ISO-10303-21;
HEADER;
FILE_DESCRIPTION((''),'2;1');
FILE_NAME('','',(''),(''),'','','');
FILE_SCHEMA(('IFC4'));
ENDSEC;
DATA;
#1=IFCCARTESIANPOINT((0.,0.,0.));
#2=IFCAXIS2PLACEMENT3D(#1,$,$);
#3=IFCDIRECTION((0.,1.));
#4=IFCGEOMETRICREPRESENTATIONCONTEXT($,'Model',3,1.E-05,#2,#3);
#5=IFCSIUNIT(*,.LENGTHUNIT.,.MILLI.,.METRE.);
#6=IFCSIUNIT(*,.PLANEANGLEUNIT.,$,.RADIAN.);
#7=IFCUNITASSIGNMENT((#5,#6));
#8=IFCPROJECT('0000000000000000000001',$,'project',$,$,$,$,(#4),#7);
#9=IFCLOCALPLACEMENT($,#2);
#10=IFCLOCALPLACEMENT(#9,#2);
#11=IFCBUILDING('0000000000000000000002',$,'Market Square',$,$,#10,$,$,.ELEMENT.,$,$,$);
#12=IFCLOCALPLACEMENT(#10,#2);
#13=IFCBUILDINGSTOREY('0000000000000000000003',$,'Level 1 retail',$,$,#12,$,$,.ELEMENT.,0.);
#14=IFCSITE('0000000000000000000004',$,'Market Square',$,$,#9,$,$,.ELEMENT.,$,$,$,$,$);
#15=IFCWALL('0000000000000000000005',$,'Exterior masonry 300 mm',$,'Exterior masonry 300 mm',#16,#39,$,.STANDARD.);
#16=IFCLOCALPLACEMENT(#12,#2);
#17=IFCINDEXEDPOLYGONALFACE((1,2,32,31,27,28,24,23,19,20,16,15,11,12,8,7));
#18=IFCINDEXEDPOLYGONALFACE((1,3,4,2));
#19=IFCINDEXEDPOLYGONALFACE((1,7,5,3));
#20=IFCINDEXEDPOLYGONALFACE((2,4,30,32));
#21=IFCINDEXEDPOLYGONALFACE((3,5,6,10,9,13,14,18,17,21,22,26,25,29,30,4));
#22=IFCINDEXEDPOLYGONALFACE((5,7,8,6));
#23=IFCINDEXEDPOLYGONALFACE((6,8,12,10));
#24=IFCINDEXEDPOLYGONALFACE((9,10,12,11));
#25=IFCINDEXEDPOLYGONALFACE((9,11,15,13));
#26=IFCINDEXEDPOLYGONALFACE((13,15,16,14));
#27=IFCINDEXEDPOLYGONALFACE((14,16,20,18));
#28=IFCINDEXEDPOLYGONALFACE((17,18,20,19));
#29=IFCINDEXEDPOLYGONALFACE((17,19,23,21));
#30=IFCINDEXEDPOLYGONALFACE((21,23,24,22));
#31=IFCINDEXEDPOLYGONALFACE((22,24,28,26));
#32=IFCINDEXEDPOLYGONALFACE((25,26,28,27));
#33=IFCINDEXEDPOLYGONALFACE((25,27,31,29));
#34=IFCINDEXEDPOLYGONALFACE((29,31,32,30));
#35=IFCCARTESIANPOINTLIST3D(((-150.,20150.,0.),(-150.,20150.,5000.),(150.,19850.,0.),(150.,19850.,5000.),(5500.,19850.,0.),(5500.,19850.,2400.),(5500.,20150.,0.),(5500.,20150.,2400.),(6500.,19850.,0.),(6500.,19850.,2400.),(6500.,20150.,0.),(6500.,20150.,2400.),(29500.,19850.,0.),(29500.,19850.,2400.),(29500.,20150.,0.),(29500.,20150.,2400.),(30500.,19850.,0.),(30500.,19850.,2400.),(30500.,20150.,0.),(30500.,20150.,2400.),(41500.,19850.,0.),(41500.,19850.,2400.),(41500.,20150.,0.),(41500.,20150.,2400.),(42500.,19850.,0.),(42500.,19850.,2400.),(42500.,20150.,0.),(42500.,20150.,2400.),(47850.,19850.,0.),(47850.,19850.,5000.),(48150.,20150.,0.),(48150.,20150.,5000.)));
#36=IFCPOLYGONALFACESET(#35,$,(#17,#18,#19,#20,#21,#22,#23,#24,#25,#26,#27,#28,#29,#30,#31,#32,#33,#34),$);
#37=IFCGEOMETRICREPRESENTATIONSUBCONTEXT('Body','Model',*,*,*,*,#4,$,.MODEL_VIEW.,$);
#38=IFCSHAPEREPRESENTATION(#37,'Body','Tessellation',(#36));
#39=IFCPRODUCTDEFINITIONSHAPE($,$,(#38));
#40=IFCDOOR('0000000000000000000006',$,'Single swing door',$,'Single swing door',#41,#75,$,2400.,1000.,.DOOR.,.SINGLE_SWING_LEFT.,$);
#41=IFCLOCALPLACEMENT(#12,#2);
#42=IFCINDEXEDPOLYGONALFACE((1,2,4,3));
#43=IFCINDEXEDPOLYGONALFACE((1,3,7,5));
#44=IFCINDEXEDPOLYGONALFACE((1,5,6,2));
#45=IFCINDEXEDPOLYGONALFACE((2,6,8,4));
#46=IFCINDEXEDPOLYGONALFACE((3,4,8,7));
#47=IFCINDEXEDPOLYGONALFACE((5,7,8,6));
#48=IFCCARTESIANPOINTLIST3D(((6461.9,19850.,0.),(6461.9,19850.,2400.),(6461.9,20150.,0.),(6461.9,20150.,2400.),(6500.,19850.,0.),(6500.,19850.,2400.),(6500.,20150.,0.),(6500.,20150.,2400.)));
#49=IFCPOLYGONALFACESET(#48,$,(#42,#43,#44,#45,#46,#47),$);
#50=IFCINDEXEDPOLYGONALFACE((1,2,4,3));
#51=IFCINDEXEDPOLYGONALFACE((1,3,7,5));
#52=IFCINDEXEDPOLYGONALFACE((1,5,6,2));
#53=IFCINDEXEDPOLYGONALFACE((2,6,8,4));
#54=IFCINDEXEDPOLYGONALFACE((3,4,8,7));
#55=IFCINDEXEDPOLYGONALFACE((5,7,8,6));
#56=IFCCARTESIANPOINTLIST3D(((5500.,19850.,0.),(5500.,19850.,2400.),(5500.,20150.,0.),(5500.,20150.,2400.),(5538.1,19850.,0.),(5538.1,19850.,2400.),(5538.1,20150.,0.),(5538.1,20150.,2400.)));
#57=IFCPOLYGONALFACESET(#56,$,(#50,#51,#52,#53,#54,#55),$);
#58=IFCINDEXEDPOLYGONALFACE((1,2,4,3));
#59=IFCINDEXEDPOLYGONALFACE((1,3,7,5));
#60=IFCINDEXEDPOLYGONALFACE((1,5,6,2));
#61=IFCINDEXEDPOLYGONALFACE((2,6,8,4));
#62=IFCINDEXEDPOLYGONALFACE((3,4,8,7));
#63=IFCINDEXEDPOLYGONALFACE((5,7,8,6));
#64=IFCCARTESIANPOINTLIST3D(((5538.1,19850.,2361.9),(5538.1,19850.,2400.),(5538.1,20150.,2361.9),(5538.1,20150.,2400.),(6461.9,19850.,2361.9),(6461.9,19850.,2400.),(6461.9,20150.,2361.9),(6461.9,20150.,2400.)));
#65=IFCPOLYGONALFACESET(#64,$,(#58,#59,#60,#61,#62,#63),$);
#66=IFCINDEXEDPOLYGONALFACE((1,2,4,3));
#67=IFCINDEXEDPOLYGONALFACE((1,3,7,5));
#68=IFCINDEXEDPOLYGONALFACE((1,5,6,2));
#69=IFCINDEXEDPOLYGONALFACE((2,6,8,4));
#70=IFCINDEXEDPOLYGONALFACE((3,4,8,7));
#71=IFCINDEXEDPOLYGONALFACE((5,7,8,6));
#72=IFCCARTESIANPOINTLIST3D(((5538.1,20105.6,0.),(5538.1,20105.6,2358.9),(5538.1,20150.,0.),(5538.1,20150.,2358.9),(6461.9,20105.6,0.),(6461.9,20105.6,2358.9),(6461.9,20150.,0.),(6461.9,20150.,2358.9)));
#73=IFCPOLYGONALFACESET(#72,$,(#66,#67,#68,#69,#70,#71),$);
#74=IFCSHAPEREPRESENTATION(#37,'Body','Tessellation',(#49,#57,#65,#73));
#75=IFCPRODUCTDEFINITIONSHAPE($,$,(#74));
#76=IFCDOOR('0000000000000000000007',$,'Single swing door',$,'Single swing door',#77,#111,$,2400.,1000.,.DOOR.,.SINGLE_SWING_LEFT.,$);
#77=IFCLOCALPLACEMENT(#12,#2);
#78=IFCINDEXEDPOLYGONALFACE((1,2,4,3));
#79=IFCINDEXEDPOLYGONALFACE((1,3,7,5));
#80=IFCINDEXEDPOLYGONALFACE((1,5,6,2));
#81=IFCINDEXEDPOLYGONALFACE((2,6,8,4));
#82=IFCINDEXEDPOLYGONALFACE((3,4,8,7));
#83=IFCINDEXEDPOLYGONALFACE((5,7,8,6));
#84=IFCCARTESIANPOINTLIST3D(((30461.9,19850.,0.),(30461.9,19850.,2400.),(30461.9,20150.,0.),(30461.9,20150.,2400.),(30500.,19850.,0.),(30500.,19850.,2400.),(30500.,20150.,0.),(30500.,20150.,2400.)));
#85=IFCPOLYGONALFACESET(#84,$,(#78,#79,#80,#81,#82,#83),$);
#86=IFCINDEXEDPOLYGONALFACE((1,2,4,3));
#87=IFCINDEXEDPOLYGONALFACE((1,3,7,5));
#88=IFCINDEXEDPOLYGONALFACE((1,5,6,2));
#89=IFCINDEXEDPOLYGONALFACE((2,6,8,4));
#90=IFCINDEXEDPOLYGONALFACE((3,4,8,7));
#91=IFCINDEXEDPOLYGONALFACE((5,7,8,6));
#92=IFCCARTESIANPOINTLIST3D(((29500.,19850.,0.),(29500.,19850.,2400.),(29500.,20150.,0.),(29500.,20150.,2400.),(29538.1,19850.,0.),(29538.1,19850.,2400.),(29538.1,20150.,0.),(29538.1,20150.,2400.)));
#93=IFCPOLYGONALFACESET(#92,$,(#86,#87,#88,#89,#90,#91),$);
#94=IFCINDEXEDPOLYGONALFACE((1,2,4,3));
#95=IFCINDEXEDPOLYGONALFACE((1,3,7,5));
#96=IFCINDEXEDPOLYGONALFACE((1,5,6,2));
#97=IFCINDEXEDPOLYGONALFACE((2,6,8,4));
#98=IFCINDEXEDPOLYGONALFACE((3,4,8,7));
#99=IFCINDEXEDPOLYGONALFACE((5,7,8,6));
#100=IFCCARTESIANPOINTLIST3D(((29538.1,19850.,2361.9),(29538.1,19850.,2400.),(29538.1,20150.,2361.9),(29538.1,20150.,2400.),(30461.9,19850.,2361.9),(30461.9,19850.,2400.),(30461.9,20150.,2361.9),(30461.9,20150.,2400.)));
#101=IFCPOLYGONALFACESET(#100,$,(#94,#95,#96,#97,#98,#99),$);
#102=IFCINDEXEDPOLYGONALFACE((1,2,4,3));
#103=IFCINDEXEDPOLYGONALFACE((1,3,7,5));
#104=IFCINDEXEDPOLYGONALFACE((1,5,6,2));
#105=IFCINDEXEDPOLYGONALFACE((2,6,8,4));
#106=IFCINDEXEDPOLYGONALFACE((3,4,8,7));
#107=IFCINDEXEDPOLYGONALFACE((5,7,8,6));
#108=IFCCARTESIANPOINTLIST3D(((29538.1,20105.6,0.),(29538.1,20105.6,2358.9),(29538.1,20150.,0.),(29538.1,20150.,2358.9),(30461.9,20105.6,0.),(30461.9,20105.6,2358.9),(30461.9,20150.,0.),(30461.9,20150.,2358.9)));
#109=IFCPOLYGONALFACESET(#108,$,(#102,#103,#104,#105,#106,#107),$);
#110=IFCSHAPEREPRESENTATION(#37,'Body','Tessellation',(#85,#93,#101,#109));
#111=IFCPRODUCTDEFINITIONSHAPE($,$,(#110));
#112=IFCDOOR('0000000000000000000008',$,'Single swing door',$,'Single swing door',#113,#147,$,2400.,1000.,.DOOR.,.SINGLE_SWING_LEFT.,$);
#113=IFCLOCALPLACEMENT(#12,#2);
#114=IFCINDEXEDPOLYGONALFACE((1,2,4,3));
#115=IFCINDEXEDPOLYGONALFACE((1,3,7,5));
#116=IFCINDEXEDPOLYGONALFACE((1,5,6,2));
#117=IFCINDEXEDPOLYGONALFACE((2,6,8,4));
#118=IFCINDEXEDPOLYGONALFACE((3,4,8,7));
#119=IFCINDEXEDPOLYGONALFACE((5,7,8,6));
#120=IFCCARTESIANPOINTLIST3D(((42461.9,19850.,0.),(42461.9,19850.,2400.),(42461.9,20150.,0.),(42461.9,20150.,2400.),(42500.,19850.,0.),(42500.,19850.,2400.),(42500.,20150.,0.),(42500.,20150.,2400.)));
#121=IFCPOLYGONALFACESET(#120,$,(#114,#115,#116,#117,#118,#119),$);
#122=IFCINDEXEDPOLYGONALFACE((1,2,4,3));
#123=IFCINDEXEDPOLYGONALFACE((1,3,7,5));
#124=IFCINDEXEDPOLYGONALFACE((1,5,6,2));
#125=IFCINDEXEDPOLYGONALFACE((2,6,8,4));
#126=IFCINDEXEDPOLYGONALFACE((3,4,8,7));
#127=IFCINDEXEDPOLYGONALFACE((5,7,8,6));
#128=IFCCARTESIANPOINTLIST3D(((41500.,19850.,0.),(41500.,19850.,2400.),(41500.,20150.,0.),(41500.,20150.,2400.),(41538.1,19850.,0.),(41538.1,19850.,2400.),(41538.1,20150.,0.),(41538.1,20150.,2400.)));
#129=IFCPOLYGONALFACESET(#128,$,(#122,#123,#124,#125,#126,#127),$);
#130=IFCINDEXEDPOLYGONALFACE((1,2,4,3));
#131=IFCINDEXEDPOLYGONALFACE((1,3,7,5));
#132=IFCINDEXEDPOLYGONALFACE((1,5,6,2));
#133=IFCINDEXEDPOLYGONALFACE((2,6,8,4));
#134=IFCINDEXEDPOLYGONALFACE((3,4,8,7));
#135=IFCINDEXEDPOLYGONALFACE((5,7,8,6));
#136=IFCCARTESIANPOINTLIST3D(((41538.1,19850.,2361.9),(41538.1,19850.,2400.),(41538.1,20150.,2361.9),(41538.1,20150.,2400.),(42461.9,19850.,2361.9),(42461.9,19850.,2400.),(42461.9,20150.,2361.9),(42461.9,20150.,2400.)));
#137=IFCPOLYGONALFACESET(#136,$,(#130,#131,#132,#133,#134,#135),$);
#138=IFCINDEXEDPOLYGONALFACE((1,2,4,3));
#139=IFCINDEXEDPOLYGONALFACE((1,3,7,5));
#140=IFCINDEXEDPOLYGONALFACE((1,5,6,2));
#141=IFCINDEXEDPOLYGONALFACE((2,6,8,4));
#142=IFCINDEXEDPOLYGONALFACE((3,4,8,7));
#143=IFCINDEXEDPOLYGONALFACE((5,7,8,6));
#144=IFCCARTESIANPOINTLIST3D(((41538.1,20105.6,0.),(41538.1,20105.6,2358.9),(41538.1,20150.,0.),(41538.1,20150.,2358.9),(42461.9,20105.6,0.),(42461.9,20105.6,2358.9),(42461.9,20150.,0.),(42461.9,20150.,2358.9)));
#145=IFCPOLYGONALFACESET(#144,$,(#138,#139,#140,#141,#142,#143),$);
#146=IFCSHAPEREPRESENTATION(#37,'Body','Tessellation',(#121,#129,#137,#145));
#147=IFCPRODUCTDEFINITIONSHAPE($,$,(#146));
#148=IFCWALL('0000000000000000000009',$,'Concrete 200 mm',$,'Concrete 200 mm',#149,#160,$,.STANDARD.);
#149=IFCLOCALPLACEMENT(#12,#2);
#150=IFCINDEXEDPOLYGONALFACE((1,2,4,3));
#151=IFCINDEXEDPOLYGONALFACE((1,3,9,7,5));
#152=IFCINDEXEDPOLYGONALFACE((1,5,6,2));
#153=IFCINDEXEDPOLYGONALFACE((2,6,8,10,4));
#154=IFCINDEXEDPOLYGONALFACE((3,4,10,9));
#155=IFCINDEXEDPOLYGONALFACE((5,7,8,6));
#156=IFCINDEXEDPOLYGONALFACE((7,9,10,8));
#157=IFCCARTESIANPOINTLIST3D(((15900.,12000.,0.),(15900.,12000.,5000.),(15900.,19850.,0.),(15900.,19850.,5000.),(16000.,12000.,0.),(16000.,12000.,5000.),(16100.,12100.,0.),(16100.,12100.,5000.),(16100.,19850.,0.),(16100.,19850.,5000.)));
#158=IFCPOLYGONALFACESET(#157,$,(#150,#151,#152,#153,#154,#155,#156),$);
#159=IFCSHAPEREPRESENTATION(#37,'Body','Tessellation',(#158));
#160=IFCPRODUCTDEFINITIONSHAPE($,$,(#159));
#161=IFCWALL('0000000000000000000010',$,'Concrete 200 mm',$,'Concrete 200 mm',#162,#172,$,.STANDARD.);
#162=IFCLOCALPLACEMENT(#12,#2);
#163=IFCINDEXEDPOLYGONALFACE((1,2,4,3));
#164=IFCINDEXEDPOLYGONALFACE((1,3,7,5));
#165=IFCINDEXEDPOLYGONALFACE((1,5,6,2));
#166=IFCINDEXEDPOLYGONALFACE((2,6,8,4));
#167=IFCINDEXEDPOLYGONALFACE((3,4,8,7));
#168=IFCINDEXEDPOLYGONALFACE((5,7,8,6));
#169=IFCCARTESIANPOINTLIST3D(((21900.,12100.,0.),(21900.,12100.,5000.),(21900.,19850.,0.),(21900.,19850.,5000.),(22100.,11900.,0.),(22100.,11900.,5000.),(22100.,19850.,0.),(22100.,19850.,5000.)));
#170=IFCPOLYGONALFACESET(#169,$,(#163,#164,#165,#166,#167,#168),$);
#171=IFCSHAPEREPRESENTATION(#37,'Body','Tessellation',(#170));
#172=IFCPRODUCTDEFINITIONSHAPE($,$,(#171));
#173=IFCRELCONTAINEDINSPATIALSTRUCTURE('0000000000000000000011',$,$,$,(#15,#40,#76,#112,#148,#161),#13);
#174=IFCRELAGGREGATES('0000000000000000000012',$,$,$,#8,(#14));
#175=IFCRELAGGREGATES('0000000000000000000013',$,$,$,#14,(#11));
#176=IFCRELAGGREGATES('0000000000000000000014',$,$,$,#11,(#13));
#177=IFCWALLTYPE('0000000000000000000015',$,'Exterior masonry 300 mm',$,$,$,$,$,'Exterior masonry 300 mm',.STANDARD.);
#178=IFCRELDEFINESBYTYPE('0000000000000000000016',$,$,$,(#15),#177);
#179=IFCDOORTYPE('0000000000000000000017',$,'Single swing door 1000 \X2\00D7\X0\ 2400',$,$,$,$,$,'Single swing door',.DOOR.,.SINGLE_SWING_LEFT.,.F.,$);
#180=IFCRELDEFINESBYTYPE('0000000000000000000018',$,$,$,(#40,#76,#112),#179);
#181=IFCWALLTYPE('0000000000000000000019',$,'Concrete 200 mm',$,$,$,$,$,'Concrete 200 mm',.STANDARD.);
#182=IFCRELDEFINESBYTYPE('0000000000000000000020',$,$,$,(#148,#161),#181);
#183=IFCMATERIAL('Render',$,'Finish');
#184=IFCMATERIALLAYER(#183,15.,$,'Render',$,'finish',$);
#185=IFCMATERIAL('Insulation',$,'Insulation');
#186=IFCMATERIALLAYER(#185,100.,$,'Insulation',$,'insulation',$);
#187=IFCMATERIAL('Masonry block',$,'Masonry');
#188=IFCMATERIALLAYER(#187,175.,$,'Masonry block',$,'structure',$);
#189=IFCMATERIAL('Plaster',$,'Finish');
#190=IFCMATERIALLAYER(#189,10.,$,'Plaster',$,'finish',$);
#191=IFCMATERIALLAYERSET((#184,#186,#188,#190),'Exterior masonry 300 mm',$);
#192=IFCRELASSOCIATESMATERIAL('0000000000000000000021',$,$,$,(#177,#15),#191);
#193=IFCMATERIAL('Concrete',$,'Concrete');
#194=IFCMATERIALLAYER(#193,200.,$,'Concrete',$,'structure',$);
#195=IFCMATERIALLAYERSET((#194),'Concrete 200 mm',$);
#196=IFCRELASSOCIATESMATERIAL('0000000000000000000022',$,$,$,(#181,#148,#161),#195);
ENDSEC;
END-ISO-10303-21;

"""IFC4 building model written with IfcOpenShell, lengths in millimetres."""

from ifc_helpers import new_model, si_unit, direction, frame, origin, origin_with_axes, place, context, subcontext, project, spatial, polyline, outline, extrude, material, layer, layer_set, layer_usage, type_object, element, fill, save


model = new_model("IFC4")

# Units and contexts
model_context = context("Model", 3, precision=1e-05, world=origin(), true_north=direction((0.0, 1.0)))
body_context = subcontext(model_context, "Body", "Model", "MODEL_VIEW")
ifc_project = project(units=[si_unit("LENGTHUNIT", "METRE", prefix="MILLI"), si_unit("PLANEANGLEUNIT", "RADIAN")], contexts=[model_context])

# Site, building, storey
site_placement = place(None, origin())
site = spatial("IfcSite", under=ifc_project, at=site_placement, Name="Market Square", CompositionType="ELEMENT")
building_placement = place(site_placement, origin())
building = spatial("IfcBuilding", under=site, at=building_placement, Name="Market Square", CompositionType="ELEMENT")
storey_placement = place(building_placement, origin())
storey = spatial("IfcBuildingStorey", under=building, at=storey_placement, Name="Level 1 retail", CompositionType="ELEMENT", Elevation=0.0)

# Shared definitions
ifc_material_1 = material(Name="Render", Category="Finish")
ifc_layer_1 = layer(ifc_material_1, 15.0, Name="Render", Category="finish")
ifc_material_2 = material(Name="Insulation", Category="Insulation")
ifc_layer_2 = layer(ifc_material_2, 100.0, Name="Insulation", Category="insulation")
ifc_material_3 = material(Name="Masonry block", Category="Masonry")
ifc_layer_3 = layer(ifc_material_3, 175.0, Name="Masonry block", Category="structure")
ifc_material_4 = material(Name="Plaster", Category="Finish")
ifc_layer_4 = layer(ifc_material_4, 10.0, Name="Plaster", Category="finish")
ifc_layer_set_1 = layer_set([ifc_layer_1, ifc_layer_2, ifc_layer_3, ifc_layer_4], Name="Exterior masonry 300 mm")
wall_type_1 = type_object("IfcWallType", Name="Exterior masonry 300 mm", ElementType="Exterior masonry 300 mm", PredefinedType="STANDARD", material=ifc_layer_set_1)

# Wall, openings, doors
ifc_layer_usage_1 = layer_usage(ifc_layer_set_1, "AXIS2", "POSITIVE", -150.0)
wall_1_placement = place(storey_placement, frame((48000.0, 20000.0, 0.0), z_axis=(0.0, 0.0, 1.0), x_axis=(-1.0, 0.0, 0.0)))
wall_1 = element("IfcWall", 1, at=wall_1_placement, inside=storey, type_object=wall_type_1, material=ifc_layer_usage_1, Name="Exterior masonry 300 mm", ObjectType="Exterior masonry 300 mm", PredefinedType="STANDARD", context=body_context, shape_type="SweptSolid", body=[
    extrude(outline(polyline([(-150.0, -150.0), (48150.0, -150.0), (47850.0, 150.0), (150.0, 150.0), (-150.0, -150.0)])), origin(), (0.0, 0.0, 1.0), 5000.0),
])
opening_1_placement = place(wall_1_placement, frame((41500.0, 0.0, 0.0), z_axis=(0.0, 0.0, 1.0), x_axis=(1.0, 0.0, 0.0)))
opening_1 = element("IfcOpeningElement", 2, at=opening_1_placement, cuts=wall_1, PredefinedType="OPENING", context=body_context, shape_type="SweptSolid", body=[
    extrude(outline(polyline([(0.0, -160.0), (1000.0, -160.0), (1000.0, 160.0), (0.0, 160.0), (0.0, -160.0)])), origin(), (0.0, 0.0, 1.0), 2400.0),
])
opening_2_placement = place(wall_1_placement, frame((17500.0, 0.0, 0.0), z_axis=(0.0, 0.0, 1.0), x_axis=(1.0, 0.0, 0.0)))
opening_2 = element("IfcOpeningElement", 3, at=opening_2_placement, cuts=wall_1, PredefinedType="OPENING", context=body_context, shape_type="SweptSolid", body=[
    extrude(outline(polyline([(0.0, -160.0), (1000.0, -160.0), (1000.0, 160.0), (0.0, 160.0), (0.0, -160.0)])), origin(), (0.0, 0.0, 1.0), 2400.0),
])
opening_3_placement = place(wall_1_placement, frame((5500.0, 0.0, 0.0), z_axis=(0.0, 0.0, 1.0), x_axis=(1.0, 0.0, 0.0)))
opening_3 = element("IfcOpeningElement", 4, at=opening_3_placement, cuts=wall_1, PredefinedType="OPENING", context=body_context, shape_type="SweptSolid", body=[
    extrude(outline(polyline([(0.0, -160.0), (1000.0, -160.0), (1000.0, 160.0), (0.0, 160.0), (0.0, -160.0)])), origin(), (0.0, 0.0, 1.0), 2400.0),
])
door_type_1 = type_object("IfcDoorType", Name="Single swing door 1000 × 2400", ElementType="Single swing door", OperationType="SINGLE_SWING_LEFT", ParameterTakesPrecedence=False, PredefinedType="DOOR")
door_1_placement = place(opening_1_placement, origin_with_axes())
door_1 = element("IfcDoor", 5, at=door_1_placement, inside=storey, type_object=door_type_1, Name="Single swing door", ObjectType="Single swing door", OperationType="SINGLE_SWING_LEFT", OverallHeight=2400.0, OverallWidth=1000.0, PredefinedType="DOOR", context=body_context, shape_type="SweptSolid", body=[
    extrude(outline(polyline([(0.0, -150.0), (38.1, -150.0), (38.1, 150.0), (0.0, 150.0), (0.0, -150.0)])), origin(), (0.0, 0.0, 1.0), 2400.0),
    extrude(outline(polyline([(961.9, -150.0), (1000.0, -150.0), (1000.0, 150.0), (961.9, 150.0), (961.9, -150.0)])), origin(), (0.0, 0.0, 1.0), 2400.0),
    extrude(outline(polyline([(38.1, -150.0), (961.9, -150.0), (961.9, 150.0), (38.1, 150.0), (38.1, -150.0)])), frame((0.0, 0.0, 2361.9)), (0.0, 0.0, 1.0), 38.1),
    extrude(outline(polyline([(38.1, -150.0), (961.9, -150.0), (961.9, -105.5), (38.1, -105.5), (38.1, -150.0)])), origin(), (0.0, 0.0, 1.0), 2358.9),
])
fill(opening_1, door_1)
door_2_placement = place(opening_2_placement, origin_with_axes())
door_2 = element("IfcDoor", 6, at=door_2_placement, inside=storey, type_object=door_type_1, Name="Single swing door", ObjectType="Single swing door", OperationType="SINGLE_SWING_LEFT", OverallHeight=2400.0, OverallWidth=1000.0, PredefinedType="DOOR", context=body_context, shape_type="SweptSolid", body=[
    extrude(outline(polyline([(0.0, -150.0), (38.1, -150.0), (38.1, 150.0), (0.0, 150.0), (0.0, -150.0)])), origin(), (0.0, 0.0, 1.0), 2400.0),
    extrude(outline(polyline([(961.9, -150.0), (1000.0, -150.0), (1000.0, 150.0), (961.9, 150.0), (961.9, -150.0)])), origin(), (0.0, 0.0, 1.0), 2400.0),
    extrude(outline(polyline([(38.1, -150.0), (961.9, -150.0), (961.9, 150.0), (38.1, 150.0), (38.1, -150.0)])), frame((0.0, 0.0, 2361.9)), (0.0, 0.0, 1.0), 38.1),
    extrude(outline(polyline([(38.1, -150.0), (961.9, -150.0), (961.9, -105.5), (38.1, -105.5), (38.1, -150.0)])), origin(), (0.0, 0.0, 1.0), 2358.9),
])
fill(opening_2, door_2)
door_3_placement = place(opening_3_placement, origin_with_axes())
door_3 = element("IfcDoor", 7, at=door_3_placement, inside=storey, type_object=door_type_1, Name="Single swing door", ObjectType="Single swing door", OperationType="SINGLE_SWING_LEFT", OverallHeight=2400.0, OverallWidth=1000.0, PredefinedType="DOOR", context=body_context, shape_type="SweptSolid", body=[
    extrude(outline(polyline([(0.0, -150.0), (38.1, -150.0), (38.1, 150.0), (0.0, 150.0), (0.0, -150.0)])), origin(), (0.0, 0.0, 1.0), 2400.0),
    extrude(outline(polyline([(961.9, -150.0), (1000.0, -150.0), (1000.0, 150.0), (961.9, 150.0), (961.9, -150.0)])), origin(), (0.0, 0.0, 1.0), 2400.0),
    extrude(outline(polyline([(38.1, -150.0), (961.9, -150.0), (961.9, 150.0), (38.1, 150.0), (38.1, -150.0)])), frame((0.0, 0.0, 2361.9)), (0.0, 0.0, 1.0), 38.1),
    extrude(outline(polyline([(38.1, -150.0), (961.9, -150.0), (961.9, -105.5), (38.1, -105.5), (38.1, -150.0)])), origin(), (0.0, 0.0, 1.0), 2358.9),
])
fill(opening_3, door_3)

# Walls
ifc_material_5 = material(Name="Concrete", Category="Concrete")
ifc_layer_5 = layer(ifc_material_5, 200.0, Name="Concrete", Category="structure")
ifc_layer_set_2 = layer_set([ifc_layer_5], Name="Concrete 200 mm")
ifc_layer_usage_2 = layer_usage(ifc_layer_set_2, "AXIS2", "NEGATIVE", 100.0)
wall_type_2 = type_object("IfcWallType", Name="Concrete 200 mm", ElementType="Concrete 200 mm", PredefinedType="STANDARD", material=ifc_layer_set_2)
wall_2_placement = place(storey_placement, frame((16000.0, 12000.0, 0.0), z_axis=(0.0, 0.0, 1.0), x_axis=(0.0, 1.0, 0.0)))
element("IfcWall", 8, at=wall_2_placement, inside=storey, type_object=wall_type_2, material=ifc_layer_usage_2, Name="Concrete 200 mm", ObjectType="Concrete 200 mm", PredefinedType="STANDARD", context=body_context, shape_type="SweptSolid", body=[
    extrude(outline(polyline([(100.0, -100.0), (7850.0, -100.0), (7850.0, 100.0), (0.0, 100.0), (0.0, 0.0), (100.0, -100.0)])), origin(), (0.0, 0.0, 1.0), 5000.0),
])
ifc_layer_usage_3 = layer_usage(ifc_layer_set_2, "AXIS2", "NEGATIVE", 100.0)
wall_3_placement = place(storey_placement, frame((22000.0, 12000.0, 0.0), z_axis=(0.0, 0.0, 1.0), x_axis=(0.0, 1.0, 0.0)))
element("IfcWall", 9, at=wall_3_placement, inside=storey, type_object=wall_type_2, material=ifc_layer_usage_3, Name="Concrete 200 mm", ObjectType="Concrete 200 mm", PredefinedType="STANDARD", context=body_context, shape_type="SweptSolid", body=[
    extrude(outline(polyline([(-100.0, -100.0), (7850.0, -100.0), (7850.0, 100.0), (100.0, 100.0), (-100.0, -100.0)])), origin(), (0.0, 0.0, 1.0), 5000.0),
])

save(model, "model.ifc")
